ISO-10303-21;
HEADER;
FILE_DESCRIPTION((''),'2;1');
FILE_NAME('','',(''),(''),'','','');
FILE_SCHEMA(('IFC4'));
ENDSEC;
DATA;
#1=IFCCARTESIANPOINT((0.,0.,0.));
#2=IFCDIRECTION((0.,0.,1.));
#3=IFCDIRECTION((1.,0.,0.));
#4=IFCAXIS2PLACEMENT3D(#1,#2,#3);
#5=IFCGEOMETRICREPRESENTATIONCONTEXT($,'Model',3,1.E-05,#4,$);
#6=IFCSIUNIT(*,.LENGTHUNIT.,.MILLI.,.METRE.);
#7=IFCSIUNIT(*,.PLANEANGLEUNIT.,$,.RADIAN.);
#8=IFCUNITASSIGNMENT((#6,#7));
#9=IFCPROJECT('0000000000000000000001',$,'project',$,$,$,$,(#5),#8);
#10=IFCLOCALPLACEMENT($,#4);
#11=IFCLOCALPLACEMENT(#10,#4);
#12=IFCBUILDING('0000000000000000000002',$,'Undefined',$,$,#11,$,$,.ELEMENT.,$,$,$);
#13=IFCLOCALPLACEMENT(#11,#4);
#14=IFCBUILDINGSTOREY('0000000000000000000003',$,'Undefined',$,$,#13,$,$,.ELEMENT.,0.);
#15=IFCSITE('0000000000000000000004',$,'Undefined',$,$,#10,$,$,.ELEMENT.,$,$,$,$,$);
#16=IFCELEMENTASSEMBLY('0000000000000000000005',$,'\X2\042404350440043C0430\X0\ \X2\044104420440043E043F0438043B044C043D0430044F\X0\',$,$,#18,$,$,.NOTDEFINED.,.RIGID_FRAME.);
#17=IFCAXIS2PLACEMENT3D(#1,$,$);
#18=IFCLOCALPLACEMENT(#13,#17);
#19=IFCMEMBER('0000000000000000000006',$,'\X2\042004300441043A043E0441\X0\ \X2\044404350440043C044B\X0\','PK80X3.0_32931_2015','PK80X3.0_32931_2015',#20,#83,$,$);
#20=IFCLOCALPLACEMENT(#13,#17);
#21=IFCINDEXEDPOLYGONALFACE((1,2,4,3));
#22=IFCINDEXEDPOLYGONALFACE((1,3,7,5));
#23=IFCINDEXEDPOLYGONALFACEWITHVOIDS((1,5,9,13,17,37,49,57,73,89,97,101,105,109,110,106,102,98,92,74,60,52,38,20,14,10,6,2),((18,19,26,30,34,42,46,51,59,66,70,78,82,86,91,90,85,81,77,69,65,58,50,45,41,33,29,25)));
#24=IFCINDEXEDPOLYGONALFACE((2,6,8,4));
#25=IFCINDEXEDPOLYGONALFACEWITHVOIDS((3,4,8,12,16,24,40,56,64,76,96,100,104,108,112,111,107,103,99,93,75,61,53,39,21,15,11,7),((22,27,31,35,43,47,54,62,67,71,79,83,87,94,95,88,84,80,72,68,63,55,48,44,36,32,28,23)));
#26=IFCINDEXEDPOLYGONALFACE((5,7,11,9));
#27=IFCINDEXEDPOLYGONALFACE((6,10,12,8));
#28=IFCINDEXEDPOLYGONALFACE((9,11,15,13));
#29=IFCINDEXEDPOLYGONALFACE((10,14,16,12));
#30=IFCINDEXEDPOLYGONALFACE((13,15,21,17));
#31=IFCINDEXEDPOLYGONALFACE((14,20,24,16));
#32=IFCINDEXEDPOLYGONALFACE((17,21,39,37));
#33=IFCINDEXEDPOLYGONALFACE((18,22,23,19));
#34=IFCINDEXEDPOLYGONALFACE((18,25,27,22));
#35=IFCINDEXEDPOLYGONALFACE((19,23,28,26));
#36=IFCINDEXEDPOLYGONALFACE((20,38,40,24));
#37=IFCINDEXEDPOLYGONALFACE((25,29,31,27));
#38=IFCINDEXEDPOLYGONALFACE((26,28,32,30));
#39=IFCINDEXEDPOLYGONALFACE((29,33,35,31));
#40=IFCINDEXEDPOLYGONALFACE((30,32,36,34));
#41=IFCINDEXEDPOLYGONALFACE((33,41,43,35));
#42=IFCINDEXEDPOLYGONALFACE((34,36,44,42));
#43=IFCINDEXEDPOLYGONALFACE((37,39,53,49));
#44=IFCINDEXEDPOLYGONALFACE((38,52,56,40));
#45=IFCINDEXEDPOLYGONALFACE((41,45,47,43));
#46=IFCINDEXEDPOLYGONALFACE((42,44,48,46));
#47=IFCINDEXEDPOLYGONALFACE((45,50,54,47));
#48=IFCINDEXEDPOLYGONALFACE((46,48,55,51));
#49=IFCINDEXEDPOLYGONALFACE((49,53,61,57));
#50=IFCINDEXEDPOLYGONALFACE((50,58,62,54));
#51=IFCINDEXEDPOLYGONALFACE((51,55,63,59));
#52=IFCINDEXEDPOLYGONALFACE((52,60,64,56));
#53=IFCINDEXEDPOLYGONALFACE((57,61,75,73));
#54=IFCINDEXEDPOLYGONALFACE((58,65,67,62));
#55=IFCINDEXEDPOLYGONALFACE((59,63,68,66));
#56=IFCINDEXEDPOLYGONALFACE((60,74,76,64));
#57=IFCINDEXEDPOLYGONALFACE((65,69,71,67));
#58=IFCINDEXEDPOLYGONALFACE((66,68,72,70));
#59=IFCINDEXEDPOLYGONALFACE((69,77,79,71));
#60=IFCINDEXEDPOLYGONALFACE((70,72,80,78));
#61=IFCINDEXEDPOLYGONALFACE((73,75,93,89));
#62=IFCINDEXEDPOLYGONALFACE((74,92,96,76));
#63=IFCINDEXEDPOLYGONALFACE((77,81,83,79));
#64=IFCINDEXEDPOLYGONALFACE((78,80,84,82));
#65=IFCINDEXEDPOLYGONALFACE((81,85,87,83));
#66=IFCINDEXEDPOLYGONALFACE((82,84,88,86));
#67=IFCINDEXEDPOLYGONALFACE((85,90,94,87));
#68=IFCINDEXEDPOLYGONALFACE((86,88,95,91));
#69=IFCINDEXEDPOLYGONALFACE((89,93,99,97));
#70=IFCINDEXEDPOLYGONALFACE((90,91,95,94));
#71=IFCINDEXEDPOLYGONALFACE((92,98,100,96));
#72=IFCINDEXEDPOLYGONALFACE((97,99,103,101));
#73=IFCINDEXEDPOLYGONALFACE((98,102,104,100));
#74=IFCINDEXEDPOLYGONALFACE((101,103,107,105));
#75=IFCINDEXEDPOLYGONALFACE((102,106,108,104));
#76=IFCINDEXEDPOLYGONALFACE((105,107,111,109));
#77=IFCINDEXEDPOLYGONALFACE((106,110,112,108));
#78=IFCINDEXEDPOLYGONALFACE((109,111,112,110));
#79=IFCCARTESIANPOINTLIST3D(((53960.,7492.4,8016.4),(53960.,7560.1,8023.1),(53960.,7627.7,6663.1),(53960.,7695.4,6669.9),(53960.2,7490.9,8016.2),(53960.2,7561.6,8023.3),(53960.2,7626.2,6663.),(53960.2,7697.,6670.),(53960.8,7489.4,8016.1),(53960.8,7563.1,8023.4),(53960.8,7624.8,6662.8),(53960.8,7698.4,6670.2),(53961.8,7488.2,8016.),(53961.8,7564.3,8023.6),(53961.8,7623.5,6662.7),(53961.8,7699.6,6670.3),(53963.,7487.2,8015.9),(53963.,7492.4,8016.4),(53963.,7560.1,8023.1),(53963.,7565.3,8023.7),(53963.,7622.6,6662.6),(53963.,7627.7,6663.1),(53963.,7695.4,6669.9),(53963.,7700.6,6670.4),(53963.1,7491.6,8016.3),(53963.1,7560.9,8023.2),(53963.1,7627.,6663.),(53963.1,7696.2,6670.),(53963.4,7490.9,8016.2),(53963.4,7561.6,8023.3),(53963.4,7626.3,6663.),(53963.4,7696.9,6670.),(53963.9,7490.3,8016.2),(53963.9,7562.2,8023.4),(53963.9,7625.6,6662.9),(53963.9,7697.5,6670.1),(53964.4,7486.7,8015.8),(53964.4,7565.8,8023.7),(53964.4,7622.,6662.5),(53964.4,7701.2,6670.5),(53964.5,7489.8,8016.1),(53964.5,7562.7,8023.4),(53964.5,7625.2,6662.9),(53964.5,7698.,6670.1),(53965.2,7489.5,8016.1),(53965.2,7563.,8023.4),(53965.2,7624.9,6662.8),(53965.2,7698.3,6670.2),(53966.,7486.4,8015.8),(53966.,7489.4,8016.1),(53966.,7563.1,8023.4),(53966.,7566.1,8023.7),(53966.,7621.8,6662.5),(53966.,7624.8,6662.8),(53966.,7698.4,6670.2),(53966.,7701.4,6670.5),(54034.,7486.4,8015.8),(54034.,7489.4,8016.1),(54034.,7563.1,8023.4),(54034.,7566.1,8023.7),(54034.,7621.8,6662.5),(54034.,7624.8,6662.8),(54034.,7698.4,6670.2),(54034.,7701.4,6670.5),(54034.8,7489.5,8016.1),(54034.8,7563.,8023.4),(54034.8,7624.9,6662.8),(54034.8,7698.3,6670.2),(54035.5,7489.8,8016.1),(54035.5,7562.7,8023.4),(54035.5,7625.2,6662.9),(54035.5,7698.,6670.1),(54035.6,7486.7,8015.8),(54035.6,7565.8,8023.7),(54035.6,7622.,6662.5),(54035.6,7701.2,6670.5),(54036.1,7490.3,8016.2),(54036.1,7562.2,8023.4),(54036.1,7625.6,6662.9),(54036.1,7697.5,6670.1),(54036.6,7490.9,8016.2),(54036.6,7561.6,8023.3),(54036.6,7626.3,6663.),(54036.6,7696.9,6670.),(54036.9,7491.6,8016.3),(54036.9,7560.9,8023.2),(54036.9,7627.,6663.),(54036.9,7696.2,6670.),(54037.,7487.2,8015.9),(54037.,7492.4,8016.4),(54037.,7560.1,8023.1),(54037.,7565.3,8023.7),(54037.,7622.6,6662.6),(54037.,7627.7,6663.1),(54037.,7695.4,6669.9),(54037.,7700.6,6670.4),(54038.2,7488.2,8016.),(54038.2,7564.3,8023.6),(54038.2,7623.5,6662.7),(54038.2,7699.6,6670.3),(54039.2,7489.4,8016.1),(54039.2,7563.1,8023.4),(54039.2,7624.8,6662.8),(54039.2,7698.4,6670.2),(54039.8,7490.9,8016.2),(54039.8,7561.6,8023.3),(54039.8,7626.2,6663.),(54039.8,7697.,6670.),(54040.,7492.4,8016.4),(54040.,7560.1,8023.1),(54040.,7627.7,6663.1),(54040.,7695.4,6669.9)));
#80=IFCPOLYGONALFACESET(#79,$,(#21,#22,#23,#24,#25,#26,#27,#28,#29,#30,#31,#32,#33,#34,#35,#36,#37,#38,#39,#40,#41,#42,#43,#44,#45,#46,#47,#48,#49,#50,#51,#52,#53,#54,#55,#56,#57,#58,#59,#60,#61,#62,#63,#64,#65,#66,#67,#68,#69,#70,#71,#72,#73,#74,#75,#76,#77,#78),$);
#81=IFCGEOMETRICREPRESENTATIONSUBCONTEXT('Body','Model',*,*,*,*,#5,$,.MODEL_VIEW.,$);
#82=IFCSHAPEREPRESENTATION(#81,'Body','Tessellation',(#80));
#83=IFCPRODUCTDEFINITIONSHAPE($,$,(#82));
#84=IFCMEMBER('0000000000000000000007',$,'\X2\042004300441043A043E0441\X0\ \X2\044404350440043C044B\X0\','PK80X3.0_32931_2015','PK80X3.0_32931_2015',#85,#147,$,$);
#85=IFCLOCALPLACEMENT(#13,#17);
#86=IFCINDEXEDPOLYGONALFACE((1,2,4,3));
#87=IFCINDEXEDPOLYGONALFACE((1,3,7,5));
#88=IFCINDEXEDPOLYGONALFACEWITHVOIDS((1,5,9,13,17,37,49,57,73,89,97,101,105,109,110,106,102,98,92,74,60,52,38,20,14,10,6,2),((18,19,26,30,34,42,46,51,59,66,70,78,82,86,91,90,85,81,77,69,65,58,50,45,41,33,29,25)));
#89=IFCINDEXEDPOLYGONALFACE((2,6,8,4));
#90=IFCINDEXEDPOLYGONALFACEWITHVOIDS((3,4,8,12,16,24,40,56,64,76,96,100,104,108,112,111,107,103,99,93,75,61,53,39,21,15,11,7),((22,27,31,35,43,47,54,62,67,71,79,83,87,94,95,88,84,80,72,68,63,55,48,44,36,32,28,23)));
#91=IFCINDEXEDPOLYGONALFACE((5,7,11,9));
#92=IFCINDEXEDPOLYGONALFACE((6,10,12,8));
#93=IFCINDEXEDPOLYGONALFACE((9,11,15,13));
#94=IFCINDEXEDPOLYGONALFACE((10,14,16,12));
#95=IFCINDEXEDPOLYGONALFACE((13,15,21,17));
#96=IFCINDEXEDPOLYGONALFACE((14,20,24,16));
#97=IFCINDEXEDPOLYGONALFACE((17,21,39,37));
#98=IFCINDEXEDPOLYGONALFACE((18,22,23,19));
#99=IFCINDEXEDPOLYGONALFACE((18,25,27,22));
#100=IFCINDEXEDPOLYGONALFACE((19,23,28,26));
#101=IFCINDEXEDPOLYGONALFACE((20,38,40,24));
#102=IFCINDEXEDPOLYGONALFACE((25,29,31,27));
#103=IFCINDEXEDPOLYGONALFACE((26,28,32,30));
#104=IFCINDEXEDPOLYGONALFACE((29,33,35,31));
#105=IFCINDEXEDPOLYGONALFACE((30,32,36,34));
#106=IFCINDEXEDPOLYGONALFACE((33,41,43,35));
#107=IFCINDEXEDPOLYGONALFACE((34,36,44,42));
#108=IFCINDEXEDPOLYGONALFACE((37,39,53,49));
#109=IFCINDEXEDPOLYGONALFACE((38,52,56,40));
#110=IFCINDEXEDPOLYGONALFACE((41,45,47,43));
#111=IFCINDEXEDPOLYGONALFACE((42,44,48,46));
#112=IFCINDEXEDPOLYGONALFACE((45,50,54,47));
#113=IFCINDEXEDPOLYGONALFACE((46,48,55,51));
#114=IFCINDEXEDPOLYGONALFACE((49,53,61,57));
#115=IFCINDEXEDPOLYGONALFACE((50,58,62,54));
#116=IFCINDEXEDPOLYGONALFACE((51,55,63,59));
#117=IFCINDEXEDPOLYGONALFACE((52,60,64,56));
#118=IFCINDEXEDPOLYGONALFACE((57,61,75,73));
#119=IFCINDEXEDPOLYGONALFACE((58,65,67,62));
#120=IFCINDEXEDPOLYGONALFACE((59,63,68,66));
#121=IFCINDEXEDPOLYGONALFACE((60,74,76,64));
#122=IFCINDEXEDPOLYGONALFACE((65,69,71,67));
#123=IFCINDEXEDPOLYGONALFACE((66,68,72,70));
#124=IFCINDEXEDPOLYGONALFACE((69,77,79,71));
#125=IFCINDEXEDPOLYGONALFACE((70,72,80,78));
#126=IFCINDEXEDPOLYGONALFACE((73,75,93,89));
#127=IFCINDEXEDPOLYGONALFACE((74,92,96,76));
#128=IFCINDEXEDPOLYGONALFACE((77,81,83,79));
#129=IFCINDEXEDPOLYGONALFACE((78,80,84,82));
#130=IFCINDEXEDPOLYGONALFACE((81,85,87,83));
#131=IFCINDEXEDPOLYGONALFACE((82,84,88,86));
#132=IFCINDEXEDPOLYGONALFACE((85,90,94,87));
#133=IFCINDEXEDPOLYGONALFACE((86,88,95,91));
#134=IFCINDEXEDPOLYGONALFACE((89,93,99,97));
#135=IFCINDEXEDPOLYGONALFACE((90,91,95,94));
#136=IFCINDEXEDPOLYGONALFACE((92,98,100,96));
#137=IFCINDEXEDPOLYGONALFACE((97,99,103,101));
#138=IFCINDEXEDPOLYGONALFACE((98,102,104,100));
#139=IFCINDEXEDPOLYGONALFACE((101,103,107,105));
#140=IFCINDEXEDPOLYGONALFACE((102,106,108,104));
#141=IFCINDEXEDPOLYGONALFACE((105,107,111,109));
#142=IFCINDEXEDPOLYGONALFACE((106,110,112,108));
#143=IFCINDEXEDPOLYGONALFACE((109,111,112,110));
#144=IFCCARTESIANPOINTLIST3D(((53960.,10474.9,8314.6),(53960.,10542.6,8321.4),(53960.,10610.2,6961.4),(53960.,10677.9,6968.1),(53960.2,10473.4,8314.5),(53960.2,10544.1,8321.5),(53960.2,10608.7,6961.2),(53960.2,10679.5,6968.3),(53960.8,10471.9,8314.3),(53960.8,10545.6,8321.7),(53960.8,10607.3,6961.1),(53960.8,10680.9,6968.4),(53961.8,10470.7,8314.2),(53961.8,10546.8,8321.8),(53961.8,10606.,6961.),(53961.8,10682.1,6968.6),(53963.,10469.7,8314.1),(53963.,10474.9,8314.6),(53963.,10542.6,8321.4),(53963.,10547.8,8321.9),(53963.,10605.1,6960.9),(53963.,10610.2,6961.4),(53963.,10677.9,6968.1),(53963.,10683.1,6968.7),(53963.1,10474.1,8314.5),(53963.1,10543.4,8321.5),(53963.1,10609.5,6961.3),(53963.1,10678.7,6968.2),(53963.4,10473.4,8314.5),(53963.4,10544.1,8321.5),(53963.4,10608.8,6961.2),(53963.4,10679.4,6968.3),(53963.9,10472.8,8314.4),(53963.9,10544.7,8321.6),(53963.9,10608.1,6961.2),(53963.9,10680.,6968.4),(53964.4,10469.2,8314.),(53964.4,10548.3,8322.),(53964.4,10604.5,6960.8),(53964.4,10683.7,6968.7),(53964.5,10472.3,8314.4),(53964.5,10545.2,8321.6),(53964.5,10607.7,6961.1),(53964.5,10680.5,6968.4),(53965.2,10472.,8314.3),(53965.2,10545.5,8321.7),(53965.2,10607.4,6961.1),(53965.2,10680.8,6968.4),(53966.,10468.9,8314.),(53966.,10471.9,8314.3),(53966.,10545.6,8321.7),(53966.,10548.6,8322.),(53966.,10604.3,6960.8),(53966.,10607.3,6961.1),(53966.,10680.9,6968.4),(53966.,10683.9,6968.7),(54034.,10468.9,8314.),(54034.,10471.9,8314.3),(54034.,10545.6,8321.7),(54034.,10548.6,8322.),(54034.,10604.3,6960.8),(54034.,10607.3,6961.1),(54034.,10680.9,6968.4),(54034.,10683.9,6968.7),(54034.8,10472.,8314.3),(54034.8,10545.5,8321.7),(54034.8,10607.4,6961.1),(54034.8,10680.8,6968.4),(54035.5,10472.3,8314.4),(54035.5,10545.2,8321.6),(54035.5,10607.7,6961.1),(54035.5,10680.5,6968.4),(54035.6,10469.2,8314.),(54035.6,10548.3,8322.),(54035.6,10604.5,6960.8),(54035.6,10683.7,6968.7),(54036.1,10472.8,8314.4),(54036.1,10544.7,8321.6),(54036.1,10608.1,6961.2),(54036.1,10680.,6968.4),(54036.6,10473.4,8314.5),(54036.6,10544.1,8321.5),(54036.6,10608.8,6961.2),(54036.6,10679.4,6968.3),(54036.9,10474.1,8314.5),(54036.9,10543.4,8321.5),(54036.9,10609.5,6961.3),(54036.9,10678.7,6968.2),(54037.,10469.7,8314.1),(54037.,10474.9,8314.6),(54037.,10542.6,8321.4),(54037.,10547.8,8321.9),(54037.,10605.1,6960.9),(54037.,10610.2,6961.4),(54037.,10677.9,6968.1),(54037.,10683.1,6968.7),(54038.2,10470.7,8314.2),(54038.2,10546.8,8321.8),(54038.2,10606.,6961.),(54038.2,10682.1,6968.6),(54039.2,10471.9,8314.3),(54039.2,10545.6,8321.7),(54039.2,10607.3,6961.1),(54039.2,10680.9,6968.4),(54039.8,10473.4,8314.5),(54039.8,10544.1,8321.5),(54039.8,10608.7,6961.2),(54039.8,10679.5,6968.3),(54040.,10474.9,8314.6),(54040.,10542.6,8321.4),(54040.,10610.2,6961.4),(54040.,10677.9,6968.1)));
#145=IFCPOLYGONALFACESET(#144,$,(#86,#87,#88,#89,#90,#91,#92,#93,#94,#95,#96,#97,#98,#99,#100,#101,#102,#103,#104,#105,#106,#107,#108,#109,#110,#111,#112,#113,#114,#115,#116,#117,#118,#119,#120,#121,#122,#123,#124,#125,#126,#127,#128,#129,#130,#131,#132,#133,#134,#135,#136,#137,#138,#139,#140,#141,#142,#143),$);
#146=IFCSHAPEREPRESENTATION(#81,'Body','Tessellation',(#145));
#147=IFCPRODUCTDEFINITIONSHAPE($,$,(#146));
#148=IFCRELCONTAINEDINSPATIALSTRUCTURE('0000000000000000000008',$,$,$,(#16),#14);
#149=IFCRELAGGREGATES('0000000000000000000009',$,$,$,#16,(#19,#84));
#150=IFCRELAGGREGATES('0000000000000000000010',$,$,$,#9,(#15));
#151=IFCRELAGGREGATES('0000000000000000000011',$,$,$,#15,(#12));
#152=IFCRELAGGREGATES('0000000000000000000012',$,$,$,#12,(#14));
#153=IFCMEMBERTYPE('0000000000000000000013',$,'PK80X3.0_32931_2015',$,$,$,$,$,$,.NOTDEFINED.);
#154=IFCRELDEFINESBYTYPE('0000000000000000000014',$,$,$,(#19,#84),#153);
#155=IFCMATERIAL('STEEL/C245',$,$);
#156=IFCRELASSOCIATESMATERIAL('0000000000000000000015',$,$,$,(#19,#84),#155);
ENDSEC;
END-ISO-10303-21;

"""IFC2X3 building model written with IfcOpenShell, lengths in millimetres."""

from ifc_helpers import new_model, si_unit, frame, origin_with_axes, origin_2d_with_axis, place, context, subcontext, project, spatial, hollow_rectangle, extrude, material, type_object, element, aggregate, save


model = new_model("IFC2X3")

# Units and contexts
model_context = context("Model", 3, precision=1e-05, world=origin_with_axes())
body_context = subcontext(model_context, "Body", "Model", "MODEL_VIEW")
ifc_project = project(units=[si_unit("LENGTHUNIT", "METRE", prefix="MILLI"), si_unit("PLANEANGLEUNIT", "RADIAN")], contexts=[model_context])

# Site, building, storey
site_placement = place(None, origin_with_axes())
site = spatial("IfcSite", under=ifc_project, at=site_placement, Name="Undefined", CompositionType="ELEMENT")
building_placement = place(site_placement, origin_with_axes())
building = spatial("IfcBuilding", under=site, at=building_placement, Name="Undefined", CompositionType="ELEMENT")
storey_placement = place(building_placement, origin_with_axes())
storey = spatial("IfcBuildingStorey", under=building, at=storey_placement, Name="Undefined", CompositionType="ELEMENT", Elevation=0.0)

# Shared definitions
ifc_material_1 = material(Name="STEEL/C245")

# Element assembly, members
assembly_1_placement = place(storey_placement, origin_with_axes())
assembly_1 = element("IfcElementAssembly", 1, at=assembly_1_placement, inside=storey, Name="Ферма стропильная", AssemblyPlace="NOTDEFINED", PredefinedType="RIGID_FRAME")
member_type_1 = type_object("IfcMemberType", Name="PK80X3.0_32931_2015", PredefinedType="NOTDEFINED")
member_1_placement = place(assembly_1_placement, frame((54000.0, 7526.3, 8019.8), z_axis=(0.0, 0.995037, 0.099504), x_axis=(0.0, 0.099504, -0.995037)))
member_1 = element("IfcMember", 2, at=member_1_placement, type_object=member_type_1, material=ifc_material_1, Name="Раскос фермы", Description="PK80X3.0_32931_2015", ObjectType="PK80X3.0_32931_2015", context=body_context, shape_type="SweptSolid", body=[
    extrude(hollow_rectangle(XDim=80.0, YDim=80.0, WallThickness=3.0, InnerFilletRadius=3.0, OuterFilletRadius=6.0, at=origin_2d_with_axis()), frame((1360.0, 0.0, 0.0), z_axis=(-1.0, 0.0, 0.0), x_axis=(0.0, -1.0, 0.0)), (0.0, 0.0, 1.0), 1360.0),
])
member_2_placement = place(assembly_1_placement, frame((54000.0, 10508.8, 8318.0), z_axis=(0.0, 0.995037, 0.099504), x_axis=(0.0, 0.099504, -0.995037)))
member_2 = element("IfcMember", 3, at=member_2_placement, type_object=member_type_1, material=ifc_material_1, Name="Раскос фермы", Description="PK80X3.0_32931_2015", ObjectType="PK80X3.0_32931_2015", context=body_context, shape_type="SweptSolid", body=[
    extrude(hollow_rectangle(XDim=80.0, YDim=80.0, WallThickness=3.0, InnerFilletRadius=3.0, OuterFilletRadius=6.0, at=origin_2d_with_axis()), frame((1360.0, 0.0, 0.0), z_axis=(-1.0, 0.0, 0.0), x_axis=(0.0, -1.0, 0.0)), (0.0, 0.0, 1.0), 1360.0),
])
aggregate(assembly_1, [member_1, member_2])

save(model, "model.ifc")
